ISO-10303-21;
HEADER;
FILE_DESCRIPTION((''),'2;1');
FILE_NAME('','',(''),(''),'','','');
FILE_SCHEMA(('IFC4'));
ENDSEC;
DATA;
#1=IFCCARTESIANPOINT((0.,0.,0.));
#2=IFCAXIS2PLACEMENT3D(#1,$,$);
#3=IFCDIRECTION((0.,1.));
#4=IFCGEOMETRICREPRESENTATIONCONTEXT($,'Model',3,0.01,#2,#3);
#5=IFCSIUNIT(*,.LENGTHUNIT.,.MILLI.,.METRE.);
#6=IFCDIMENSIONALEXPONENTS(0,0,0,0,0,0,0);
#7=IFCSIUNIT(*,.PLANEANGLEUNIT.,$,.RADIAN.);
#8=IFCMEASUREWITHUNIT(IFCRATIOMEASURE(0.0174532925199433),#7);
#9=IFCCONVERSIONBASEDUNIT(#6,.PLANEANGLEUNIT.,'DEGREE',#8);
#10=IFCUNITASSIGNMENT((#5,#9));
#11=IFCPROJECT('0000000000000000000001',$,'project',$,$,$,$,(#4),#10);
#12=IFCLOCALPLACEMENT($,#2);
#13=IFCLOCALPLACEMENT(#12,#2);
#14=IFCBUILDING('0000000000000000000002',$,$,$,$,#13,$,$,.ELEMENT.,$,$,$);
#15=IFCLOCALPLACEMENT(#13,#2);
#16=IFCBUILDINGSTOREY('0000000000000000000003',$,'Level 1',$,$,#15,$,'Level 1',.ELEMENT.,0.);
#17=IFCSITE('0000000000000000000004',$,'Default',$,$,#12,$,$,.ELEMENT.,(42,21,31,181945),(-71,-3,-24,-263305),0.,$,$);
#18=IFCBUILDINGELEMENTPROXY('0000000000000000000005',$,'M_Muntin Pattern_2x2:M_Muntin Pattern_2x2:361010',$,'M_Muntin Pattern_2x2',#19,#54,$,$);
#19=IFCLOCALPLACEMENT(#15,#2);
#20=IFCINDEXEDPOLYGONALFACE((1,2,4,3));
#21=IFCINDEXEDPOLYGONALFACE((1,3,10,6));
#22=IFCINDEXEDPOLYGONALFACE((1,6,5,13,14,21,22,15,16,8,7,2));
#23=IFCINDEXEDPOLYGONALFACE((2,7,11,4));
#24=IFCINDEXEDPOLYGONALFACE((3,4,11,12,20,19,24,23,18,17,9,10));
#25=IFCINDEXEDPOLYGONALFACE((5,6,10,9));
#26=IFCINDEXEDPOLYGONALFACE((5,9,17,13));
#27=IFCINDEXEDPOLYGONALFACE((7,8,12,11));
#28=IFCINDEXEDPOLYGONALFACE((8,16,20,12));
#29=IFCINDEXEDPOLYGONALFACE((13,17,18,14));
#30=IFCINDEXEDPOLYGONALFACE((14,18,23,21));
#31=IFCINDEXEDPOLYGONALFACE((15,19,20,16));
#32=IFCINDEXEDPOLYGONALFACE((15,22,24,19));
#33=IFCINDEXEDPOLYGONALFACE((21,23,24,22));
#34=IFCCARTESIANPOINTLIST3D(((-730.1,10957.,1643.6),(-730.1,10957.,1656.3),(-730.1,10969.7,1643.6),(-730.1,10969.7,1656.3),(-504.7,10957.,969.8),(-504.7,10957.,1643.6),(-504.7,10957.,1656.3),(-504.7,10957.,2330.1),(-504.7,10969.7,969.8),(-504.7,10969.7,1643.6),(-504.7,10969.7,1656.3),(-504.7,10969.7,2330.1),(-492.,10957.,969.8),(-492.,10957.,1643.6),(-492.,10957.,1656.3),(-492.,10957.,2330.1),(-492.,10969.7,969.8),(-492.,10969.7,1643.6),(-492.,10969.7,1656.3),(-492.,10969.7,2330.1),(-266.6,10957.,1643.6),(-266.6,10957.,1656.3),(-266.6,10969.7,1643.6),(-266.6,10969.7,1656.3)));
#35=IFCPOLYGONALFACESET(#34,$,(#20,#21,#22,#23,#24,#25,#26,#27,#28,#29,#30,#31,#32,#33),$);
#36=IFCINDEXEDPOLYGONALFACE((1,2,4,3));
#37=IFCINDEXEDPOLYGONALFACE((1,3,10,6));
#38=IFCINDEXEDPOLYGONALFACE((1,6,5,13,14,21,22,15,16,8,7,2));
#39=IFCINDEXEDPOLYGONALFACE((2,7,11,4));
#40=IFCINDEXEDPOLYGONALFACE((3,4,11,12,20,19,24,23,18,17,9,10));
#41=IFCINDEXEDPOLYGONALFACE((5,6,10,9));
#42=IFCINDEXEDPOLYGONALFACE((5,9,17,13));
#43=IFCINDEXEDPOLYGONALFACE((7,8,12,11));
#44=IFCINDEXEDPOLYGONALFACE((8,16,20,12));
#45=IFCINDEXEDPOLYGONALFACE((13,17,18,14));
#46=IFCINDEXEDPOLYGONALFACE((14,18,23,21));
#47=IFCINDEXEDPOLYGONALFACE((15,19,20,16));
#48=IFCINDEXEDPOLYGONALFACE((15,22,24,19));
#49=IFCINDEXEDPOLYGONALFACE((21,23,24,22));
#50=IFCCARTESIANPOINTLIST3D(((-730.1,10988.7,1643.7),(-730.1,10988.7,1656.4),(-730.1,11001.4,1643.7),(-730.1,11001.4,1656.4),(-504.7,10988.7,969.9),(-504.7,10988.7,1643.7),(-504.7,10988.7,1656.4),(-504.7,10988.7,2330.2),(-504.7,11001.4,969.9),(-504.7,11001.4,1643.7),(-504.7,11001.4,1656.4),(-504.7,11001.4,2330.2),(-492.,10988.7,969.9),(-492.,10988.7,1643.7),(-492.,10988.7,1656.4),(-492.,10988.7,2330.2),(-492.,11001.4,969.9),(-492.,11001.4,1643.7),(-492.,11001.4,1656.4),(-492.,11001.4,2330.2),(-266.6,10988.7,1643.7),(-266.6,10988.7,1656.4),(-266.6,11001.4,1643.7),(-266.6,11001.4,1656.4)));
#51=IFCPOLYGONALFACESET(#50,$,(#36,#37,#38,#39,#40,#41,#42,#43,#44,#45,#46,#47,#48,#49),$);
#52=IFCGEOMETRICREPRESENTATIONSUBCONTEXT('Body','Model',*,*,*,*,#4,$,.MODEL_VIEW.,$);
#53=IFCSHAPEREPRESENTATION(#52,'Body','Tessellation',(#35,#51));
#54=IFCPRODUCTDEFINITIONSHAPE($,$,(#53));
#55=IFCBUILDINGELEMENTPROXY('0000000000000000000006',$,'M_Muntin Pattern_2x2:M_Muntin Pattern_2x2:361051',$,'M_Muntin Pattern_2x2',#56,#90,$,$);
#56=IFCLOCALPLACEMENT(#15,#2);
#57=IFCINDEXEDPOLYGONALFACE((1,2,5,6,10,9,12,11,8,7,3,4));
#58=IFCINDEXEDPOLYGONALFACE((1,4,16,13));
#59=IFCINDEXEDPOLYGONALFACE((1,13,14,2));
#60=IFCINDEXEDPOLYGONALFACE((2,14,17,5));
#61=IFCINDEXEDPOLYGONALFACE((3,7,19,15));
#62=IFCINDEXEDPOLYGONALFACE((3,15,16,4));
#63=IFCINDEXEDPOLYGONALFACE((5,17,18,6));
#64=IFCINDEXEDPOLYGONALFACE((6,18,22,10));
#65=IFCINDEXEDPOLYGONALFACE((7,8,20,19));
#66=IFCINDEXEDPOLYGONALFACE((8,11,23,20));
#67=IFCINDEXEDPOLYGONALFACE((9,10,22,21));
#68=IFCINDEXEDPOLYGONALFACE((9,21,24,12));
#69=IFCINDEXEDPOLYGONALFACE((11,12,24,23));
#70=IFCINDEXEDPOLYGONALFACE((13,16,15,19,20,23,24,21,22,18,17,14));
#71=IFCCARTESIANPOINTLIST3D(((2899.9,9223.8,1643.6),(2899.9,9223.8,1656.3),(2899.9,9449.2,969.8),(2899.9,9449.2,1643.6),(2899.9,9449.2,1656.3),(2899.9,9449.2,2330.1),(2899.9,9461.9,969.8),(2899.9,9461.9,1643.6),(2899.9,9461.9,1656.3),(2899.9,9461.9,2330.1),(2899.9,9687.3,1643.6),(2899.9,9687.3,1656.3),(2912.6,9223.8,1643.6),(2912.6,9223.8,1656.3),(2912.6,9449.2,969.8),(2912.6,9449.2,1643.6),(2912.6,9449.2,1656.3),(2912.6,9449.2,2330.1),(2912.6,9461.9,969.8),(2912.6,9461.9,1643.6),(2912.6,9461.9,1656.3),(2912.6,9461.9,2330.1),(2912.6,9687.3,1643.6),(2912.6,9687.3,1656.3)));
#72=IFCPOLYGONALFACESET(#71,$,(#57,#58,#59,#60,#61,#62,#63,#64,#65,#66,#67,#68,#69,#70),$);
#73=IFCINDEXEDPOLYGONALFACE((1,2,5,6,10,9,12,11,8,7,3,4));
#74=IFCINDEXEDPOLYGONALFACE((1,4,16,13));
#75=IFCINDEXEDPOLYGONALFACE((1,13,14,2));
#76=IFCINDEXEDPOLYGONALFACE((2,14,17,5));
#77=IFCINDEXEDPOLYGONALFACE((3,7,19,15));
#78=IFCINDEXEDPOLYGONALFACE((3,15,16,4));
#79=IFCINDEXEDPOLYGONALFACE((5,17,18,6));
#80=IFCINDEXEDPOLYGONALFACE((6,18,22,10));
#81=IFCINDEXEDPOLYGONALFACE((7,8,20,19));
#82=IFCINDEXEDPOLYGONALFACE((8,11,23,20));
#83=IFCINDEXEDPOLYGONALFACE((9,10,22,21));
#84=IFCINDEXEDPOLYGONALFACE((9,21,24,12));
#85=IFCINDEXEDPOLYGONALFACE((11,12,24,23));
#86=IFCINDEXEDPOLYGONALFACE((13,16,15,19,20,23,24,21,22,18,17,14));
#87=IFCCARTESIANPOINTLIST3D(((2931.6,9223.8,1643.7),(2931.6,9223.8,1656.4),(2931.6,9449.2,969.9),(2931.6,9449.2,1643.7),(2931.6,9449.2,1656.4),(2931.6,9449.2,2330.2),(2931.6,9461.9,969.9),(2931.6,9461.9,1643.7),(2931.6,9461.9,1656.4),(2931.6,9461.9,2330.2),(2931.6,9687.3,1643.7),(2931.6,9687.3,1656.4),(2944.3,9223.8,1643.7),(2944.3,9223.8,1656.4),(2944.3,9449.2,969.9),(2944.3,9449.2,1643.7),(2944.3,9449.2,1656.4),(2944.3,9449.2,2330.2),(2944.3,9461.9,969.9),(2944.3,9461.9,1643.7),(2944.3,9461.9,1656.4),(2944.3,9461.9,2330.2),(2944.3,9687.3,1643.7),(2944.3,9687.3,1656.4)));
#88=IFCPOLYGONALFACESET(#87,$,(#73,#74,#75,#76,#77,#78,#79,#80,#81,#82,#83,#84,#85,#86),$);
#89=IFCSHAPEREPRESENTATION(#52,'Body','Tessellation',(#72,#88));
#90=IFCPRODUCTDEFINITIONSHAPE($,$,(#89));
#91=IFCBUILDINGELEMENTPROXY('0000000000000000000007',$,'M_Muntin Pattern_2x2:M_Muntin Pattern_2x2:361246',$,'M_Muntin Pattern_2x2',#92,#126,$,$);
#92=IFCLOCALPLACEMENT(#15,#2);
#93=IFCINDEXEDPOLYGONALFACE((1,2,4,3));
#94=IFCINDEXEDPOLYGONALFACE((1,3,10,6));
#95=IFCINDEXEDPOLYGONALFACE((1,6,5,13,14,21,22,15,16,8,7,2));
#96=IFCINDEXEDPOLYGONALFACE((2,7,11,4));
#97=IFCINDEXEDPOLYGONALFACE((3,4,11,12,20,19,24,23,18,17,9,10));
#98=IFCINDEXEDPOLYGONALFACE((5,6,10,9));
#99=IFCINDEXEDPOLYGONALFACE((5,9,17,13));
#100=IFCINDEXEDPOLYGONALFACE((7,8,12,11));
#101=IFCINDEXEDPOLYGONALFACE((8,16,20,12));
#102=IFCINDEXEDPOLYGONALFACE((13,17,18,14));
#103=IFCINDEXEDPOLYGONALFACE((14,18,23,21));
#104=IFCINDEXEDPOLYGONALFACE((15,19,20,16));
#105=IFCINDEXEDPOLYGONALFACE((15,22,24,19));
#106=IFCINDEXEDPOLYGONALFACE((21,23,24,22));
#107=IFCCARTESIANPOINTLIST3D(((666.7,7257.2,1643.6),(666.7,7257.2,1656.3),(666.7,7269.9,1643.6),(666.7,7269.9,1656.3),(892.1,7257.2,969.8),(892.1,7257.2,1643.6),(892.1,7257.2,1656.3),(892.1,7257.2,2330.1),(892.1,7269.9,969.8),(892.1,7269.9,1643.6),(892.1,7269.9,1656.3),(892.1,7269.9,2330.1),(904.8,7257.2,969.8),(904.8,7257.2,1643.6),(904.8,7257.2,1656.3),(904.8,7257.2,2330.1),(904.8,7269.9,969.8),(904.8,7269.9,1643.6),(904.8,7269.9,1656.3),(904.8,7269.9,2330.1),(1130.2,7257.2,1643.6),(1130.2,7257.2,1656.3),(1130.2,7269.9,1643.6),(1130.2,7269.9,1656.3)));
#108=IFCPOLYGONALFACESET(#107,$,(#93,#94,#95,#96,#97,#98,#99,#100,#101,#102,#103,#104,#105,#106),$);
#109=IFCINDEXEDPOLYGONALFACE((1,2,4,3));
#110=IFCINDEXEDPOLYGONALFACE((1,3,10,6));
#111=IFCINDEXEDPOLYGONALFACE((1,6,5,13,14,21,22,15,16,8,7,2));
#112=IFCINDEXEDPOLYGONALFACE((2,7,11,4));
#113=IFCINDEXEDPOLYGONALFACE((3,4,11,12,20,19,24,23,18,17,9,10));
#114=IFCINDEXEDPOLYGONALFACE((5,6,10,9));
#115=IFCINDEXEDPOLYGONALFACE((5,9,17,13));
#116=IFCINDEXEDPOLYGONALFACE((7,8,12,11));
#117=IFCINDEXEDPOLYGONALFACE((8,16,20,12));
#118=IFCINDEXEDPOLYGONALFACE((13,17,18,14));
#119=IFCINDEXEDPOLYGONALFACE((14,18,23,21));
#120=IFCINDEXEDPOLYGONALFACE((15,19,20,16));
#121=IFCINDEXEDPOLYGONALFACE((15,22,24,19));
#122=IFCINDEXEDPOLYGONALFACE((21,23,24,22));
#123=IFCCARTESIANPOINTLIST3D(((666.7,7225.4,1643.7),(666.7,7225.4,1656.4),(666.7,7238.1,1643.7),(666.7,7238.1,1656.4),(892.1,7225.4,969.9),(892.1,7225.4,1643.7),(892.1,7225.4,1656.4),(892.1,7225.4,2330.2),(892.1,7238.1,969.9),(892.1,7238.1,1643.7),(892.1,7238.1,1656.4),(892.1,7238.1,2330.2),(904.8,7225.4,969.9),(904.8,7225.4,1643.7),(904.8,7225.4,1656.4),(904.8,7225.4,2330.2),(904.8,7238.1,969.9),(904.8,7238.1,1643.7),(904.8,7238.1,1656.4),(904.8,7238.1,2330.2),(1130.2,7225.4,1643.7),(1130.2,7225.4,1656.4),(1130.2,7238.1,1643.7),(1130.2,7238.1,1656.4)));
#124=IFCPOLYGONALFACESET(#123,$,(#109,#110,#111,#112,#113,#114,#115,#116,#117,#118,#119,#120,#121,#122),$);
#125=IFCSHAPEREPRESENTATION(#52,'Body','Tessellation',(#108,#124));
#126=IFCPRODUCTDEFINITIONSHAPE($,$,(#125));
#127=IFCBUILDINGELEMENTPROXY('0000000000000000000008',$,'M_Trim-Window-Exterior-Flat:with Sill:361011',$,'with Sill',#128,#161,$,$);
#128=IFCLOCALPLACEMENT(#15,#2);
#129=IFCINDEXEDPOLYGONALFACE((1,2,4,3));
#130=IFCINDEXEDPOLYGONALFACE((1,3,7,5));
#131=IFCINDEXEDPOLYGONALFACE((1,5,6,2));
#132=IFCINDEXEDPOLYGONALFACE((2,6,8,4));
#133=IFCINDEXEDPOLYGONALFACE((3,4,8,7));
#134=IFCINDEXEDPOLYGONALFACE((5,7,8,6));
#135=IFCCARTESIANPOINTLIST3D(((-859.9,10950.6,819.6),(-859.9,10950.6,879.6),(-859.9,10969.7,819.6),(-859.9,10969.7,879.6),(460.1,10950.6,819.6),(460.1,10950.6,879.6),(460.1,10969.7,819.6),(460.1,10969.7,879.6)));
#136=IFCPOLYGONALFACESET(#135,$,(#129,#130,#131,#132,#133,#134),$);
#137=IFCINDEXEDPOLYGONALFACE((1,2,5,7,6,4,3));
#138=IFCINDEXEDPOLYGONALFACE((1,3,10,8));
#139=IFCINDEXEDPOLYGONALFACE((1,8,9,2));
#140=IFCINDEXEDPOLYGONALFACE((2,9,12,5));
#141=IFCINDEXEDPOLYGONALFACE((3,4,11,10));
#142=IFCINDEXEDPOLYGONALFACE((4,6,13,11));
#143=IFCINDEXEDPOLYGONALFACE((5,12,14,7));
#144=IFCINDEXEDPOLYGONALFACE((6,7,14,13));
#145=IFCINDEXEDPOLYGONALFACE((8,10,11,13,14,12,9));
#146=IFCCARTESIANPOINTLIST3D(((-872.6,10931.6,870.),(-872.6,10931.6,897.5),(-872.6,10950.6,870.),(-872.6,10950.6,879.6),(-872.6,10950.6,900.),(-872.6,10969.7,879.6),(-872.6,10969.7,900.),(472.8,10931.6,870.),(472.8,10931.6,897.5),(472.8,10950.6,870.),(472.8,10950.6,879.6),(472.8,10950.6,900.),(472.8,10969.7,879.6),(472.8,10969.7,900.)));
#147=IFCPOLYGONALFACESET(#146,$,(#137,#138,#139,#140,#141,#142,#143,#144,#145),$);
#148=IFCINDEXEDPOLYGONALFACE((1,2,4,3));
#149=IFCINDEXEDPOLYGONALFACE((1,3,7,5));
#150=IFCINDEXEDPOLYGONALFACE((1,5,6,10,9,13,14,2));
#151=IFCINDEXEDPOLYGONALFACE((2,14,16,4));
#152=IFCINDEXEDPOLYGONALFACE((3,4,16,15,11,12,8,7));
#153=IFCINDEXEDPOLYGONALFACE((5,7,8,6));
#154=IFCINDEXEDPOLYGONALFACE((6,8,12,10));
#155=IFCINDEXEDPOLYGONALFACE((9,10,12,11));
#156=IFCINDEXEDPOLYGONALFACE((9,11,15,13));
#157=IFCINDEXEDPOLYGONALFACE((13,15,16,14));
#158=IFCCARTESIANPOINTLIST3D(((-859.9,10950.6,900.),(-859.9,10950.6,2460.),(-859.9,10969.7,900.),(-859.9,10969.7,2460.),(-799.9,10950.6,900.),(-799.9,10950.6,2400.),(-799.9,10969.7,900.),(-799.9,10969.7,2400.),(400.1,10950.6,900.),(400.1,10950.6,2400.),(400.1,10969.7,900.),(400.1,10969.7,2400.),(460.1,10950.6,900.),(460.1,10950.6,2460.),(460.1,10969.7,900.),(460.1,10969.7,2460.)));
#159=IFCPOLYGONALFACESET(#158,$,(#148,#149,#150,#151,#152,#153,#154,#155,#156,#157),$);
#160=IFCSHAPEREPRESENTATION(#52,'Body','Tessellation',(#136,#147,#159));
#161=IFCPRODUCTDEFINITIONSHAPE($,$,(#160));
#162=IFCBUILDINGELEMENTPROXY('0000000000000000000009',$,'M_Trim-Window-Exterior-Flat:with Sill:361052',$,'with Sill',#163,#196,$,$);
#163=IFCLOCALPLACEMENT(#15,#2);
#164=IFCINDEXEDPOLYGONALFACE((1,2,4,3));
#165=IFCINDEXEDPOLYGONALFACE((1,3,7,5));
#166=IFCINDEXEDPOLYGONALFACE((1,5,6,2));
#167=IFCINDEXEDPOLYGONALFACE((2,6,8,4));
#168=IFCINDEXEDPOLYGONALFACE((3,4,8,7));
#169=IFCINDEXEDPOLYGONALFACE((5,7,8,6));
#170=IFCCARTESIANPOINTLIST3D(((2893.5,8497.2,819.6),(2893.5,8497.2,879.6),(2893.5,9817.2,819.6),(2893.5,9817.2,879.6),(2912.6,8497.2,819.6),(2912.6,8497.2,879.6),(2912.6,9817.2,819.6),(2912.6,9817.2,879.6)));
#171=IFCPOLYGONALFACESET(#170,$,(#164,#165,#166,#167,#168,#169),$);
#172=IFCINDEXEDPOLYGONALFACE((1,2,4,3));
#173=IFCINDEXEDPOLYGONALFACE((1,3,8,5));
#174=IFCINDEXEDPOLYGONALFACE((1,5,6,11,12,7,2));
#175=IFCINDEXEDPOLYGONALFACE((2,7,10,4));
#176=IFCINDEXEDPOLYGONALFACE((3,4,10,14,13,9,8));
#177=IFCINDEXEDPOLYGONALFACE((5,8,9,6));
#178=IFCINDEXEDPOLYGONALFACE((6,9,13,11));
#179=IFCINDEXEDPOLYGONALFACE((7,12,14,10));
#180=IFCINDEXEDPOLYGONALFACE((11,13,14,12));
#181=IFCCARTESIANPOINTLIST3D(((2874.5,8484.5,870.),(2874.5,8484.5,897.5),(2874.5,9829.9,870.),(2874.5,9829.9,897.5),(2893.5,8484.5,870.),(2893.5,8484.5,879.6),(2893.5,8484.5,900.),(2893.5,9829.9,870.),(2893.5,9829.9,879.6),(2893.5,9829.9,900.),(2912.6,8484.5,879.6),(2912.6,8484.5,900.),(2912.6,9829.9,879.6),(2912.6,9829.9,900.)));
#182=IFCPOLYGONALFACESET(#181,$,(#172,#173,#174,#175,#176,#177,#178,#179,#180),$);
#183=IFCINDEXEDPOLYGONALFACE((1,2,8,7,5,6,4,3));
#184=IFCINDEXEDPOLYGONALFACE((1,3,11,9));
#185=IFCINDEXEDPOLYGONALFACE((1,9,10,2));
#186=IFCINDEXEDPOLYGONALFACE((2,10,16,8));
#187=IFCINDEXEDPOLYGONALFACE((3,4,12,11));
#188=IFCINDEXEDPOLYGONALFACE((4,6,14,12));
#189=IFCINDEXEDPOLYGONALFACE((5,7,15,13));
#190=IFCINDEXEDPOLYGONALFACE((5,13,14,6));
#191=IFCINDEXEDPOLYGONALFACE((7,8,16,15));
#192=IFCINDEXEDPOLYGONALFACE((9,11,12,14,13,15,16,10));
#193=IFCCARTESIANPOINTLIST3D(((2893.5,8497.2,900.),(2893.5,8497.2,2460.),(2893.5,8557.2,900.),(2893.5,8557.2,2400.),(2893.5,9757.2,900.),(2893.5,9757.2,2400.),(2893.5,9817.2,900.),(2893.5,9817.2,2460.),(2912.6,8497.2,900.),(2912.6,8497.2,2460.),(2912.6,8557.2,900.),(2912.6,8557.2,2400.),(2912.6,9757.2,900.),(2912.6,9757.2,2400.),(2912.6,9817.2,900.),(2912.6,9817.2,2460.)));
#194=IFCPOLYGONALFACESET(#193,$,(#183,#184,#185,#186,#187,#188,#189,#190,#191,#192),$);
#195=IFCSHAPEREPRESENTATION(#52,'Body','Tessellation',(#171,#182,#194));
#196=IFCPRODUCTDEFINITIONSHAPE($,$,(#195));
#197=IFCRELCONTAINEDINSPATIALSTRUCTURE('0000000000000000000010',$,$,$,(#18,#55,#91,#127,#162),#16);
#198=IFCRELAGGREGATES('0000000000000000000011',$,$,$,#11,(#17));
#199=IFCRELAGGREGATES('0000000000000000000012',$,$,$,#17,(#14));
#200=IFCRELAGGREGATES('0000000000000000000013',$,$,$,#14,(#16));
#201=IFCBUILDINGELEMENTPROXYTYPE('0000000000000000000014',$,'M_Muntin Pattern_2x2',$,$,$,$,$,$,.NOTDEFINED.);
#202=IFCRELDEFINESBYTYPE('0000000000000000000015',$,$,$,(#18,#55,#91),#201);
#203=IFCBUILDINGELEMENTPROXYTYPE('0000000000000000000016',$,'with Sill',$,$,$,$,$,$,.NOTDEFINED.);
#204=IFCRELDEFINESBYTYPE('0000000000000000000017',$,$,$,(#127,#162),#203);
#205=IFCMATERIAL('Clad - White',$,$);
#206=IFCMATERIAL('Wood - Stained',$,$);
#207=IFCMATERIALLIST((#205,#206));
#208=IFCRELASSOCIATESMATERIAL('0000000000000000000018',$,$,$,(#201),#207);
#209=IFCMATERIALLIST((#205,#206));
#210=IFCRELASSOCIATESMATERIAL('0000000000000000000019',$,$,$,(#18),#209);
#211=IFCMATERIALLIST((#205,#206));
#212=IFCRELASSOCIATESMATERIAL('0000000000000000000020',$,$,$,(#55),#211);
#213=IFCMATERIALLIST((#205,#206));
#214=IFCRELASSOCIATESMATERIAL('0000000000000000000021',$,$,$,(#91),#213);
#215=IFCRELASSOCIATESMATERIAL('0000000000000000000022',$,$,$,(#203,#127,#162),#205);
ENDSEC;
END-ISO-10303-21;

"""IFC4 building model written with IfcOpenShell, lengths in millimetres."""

from ifc_helpers import new_model, entity, si_unit, converted_unit, direction, frame, frame_2d, origin, place, context, subcontext, project, spatial, polyline, rectangle, outline, extrude, source, transform, mapped, material, material_list, type_object, type_shapes, element, save


model = new_model("IFC4")

# Units and contexts
model_context = context("Model", 3, precision=0.01, world=origin(), true_north=direction((0.0, 1.0)))
body_context = subcontext(model_context, "Body", "Model", "MODEL_VIEW")
ifc_project = project(units=[si_unit("LENGTHUNIT", "METRE", prefix="MILLI"), converted_unit("PLANEANGLEUNIT", "DEGREE", entity("IfcRatioMeasure", 0.0174532925199433), si_unit("PLANEANGLEUNIT", "RADIAN"), dimensions=[0, 0, 0, 0, 0, 0, 0])], contexts=[model_context])

# Site, building, storey
site_placement = place(None, origin())
site = spatial("IfcSite", under=ifc_project, at=site_placement, Name="Default", CompositionType="ELEMENT", RefLatitude=(42, 21, 31, 181945), RefLongitude=(-71, -3, -24, -263305), RefElevation=0.0)
building_placement = place(site_placement, origin())
building = spatial("IfcBuilding", under=site, at=building_placement, CompositionType="ELEMENT")
storey_placement = place(building_placement, origin())
storey = spatial("IfcBuildingStorey", under=building, at=storey_placement, Name="Level 1", LongName="Level 1", CompositionType="ELEMENT", Elevation=0.0)

# Building element proxies
ifc_material_1 = material(Name="Clad - White")
ifc_material_2 = material(Name="Wood - Stained")
ifc_material_list_1 = material_list([ifc_material_1, ifc_material_2])
ifc_material_list_2 = material_list([ifc_material_1, ifc_material_2])
building_element_proxy_type_1 = type_object("IfcBuildingElementProxyType", Name="M_Muntin Pattern_2x2", PredefinedType="NOTDEFINED", material=ifc_material_list_2)
shared_shape_1 = source(origin(), body_context, "Body", "SweptSolid", [
    extrude(outline(polyline([(6.4, -6.4), (680.1, -6.4), (680.1, 6.3), (6.4, 6.3), (6.4, 231.7), (-6.3, 231.7), (-6.3, 6.3), (-680.2, 6.3), (-680.2, -6.4), (-6.3, -6.4), (-6.3, -231.7), (6.4, -231.7), (6.4, -6.4)])), frame((0.0, -22.2, 680.1), z_axis=(0.0, 1.0, 0.0), x_axis=(0.0, 0.0, 1.0)), (0.0, 0.0, 1.0), 12.7),
    extrude(outline(polyline([(6.4, -6.4), (680.1, -6.4), (680.1, 6.3), (6.4, 6.3), (6.4, 231.7), (-6.3, 231.7), (-6.3, 6.3), (-680.2, 6.3), (-680.2, -6.4), (-6.3, -6.4), (-6.3, -231.7), (6.4, -231.7), (6.4, -6.4)])), frame((0.0, 9.5, 680.2), z_axis=(0.0, 1.0, 0.0), x_axis=(0.0, 0.0, 1.0)), (0.0, 0.0, 1.0), 12.7),
])
type_shapes(building_element_proxy_type_1, [shared_shape_1])
proxy_1_placement = place(storey_placement, frame((-498.4, 10979.2, 969.9)))
element("IfcBuildingElementProxy", 1, at=proxy_1_placement, inside=storey, type_object=building_element_proxy_type_1, material=ifc_material_list_1, Name="M_Muntin Pattern_2x2:M_Muntin Pattern_2x2:361010", ObjectType="M_Muntin Pattern_2x2", context=body_context, shape_type="MappedRepresentation", body=[
    mapped(shared_shape_1, transform((0.0, 0.0, 0.0), scale=1.0)),
])
ifc_material_list_3 = material_list([ifc_material_1, ifc_material_2])
proxy_2_placement = place(storey_placement, frame((2922.1, 9455.6, 969.9), z_axis=(0.0, 0.0, 1.0), x_axis=(0.0, -1.0, 0.0)))
element("IfcBuildingElementProxy", 2, at=proxy_2_placement, inside=storey, type_object=building_element_proxy_type_1, material=ifc_material_list_3, Name="M_Muntin Pattern_2x2:M_Muntin Pattern_2x2:361051", ObjectType="M_Muntin Pattern_2x2", context=body_context, shape_type="MappedRepresentation", body=[
    mapped(shared_shape_1, transform((0.0, 0.0, 0.0), scale=1.0)),
])
ifc_material_list_4 = material_list([ifc_material_1, ifc_material_2])
proxy_3_placement = place(storey_placement, frame((898.5, 7247.6, 969.9), z_axis=(0.0, 0.0, 1.0), x_axis=(-1.0, 0.0, 0.0)))
element("IfcBuildingElementProxy", 3, at=proxy_3_placement, inside=storey, type_object=building_element_proxy_type_1, material=ifc_material_list_4, Name="M_Muntin Pattern_2x2:M_Muntin Pattern_2x2:361246", ObjectType="M_Muntin Pattern_2x2", context=body_context, shape_type="MappedRepresentation", body=[
    mapped(shared_shape_1, transform((0.0, 0.0, 0.0), scale=1.0)),
])
building_element_proxy_type_2 = type_object("IfcBuildingElementProxyType", Name="with Sill", PredefinedType="NOTDEFINED", material=ifc_material_1)
shared_shape_2 = source(origin(), body_context, "Body", "SweptSolid", [
    extrude(rectangle(XDim=1320.0, YDim=60.0, at=frame_2d((0.0, 0.0), x_axis=(1.0, 0.0))), frame((0.0, -1550.4, 0.0), z_axis=(0.0, 0.0, 1.0), x_axis=(-1.0, 0.0, 0.0)), (0.0, 0.0, 1.0), 19.1),
    extrude(outline(polyline([(-19.0, -15.2), (0.0, -15.2), (0.0, -5.7), (19.0, -5.7), (19.0, 14.8), (0.0, 14.8), (-19.0, 12.3), (-19.0, -15.2)])), frame((-672.7, -1514.8, 19.0), z_axis=(1.0, 0.0, 0.0), x_axis=(0.0, 0.0, -1.0)), (0.0, 0.0, 1.0), 1345.4),
    extrude(outline(polyline([(-795.0, -660.0), (765.0, -660.0), (765.0, -600.0), (-735.0, -600.0), (-735.0, 600.0), (765.0, 600.0), (765.0, 660.0), (-795.0, 660.0), (-795.0, -660.0)])), frame((0.0, -735.0, 0.0), z_axis=(0.0, 0.0, 1.0), x_axis=(0.0, -1.0, 0.0)), (0.0, 0.0, 1.0), 19.1),
])
type_shapes(building_element_proxy_type_2, [shared_shape_2])
for number, where, z_axis, x_axis, name in (
    (4, (-199.9, 10969.7, 2400.0), (0.0, -1.0, 0.0), (1.0, 0.0, 0.0), "M_Trim-Window-Exterior-Flat:with Sill:361011"),
    (5, (2912.6, 9157.2, 2400.0), (-1.0, 0.0, 0.0), (0.0, -1.0, 0.0), "M_Trim-Window-Exterior-Flat:with Sill:361052"),
):
    element("IfcBuildingElementProxy", number, at=place(storey_placement, frame(where, z_axis=z_axis, x_axis=x_axis)), inside=storey, type_object=building_element_proxy_type_2, material=ifc_material_1, Name=name, ObjectType="with Sill", context=body_context, shape_type="MappedRepresentation", body=[
        mapped(shared_shape_2, transform((0.0, 0.0, 0.0), scale=1.0)),
    ])

save(model, "model.ifc")
